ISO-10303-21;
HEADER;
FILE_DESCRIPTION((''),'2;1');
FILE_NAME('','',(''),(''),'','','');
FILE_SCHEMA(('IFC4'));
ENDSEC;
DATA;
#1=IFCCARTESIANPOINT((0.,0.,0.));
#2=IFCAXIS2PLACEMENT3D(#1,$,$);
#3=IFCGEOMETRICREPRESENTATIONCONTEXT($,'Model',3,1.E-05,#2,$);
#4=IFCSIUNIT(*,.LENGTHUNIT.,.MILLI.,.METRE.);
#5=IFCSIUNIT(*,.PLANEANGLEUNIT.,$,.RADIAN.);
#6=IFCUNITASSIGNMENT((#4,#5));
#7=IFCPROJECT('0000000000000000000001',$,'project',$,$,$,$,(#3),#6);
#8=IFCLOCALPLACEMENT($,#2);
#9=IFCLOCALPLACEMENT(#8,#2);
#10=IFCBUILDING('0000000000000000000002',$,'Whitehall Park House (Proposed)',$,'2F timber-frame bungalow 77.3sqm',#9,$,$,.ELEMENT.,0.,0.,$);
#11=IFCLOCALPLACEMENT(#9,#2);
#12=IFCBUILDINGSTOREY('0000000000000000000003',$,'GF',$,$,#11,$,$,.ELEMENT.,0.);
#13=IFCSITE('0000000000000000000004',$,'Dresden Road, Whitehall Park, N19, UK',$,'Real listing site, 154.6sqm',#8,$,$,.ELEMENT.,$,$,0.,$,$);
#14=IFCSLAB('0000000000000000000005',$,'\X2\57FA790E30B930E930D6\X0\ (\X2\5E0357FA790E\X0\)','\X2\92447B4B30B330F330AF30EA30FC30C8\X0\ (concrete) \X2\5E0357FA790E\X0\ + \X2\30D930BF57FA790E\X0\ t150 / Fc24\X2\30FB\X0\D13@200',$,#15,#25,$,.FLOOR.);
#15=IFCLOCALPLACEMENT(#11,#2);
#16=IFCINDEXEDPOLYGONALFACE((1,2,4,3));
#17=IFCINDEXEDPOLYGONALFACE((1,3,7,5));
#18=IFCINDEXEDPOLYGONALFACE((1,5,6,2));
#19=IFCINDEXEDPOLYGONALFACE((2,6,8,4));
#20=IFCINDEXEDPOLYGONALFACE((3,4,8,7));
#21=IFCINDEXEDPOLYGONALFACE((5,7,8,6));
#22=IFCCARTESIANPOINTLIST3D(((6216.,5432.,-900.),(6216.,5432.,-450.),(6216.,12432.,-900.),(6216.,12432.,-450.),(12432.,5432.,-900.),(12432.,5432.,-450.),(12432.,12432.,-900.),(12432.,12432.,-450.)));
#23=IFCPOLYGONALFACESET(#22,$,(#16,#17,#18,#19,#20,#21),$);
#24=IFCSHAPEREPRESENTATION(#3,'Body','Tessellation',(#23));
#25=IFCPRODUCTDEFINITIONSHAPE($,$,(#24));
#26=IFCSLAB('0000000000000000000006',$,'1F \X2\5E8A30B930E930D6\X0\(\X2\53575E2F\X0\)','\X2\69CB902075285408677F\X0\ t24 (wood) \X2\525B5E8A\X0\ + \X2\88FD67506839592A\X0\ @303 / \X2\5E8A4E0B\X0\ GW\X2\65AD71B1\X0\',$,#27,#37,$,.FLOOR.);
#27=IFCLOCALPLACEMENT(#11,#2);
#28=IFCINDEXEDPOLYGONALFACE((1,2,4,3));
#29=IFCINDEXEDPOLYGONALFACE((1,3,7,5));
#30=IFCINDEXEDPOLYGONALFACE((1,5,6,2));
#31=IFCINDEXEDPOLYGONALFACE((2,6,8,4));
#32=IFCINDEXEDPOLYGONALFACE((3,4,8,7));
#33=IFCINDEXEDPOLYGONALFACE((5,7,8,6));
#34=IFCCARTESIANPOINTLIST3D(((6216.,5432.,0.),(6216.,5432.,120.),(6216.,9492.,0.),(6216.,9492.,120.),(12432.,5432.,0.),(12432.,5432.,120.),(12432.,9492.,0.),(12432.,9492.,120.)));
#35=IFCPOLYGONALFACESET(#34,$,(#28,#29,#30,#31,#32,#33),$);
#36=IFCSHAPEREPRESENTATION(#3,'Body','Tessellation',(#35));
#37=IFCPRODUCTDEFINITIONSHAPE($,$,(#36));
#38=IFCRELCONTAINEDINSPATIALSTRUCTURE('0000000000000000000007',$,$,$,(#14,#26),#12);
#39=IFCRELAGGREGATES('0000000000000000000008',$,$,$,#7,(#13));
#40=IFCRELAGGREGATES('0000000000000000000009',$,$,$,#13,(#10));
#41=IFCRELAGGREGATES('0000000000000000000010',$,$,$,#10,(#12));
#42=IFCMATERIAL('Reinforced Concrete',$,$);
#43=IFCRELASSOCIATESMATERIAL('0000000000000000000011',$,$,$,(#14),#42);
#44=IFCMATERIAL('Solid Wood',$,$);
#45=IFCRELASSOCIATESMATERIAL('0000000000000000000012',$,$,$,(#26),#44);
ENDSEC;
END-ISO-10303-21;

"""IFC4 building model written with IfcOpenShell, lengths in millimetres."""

from ifc_helpers import new_model, si_unit, frame, frame_2d, origin, place, context, project, spatial, rectangle, extrude, material, element, save


model = new_model("IFC4")

# Units and contexts
model_context = context("Model", 3, precision=1e-05, world=origin())
ifc_project = project(units=[si_unit("LENGTHUNIT", "METRE", prefix="MILLI"), si_unit("PLANEANGLEUNIT", "RADIAN")], contexts=[model_context])

# Site, building, storey
site_placement = place(None, origin())
site = spatial("IfcSite", under=ifc_project, at=site_placement, Name="Dresden Road, Whitehall Park, N19, UK", ObjectType="Real listing site, 154.6sqm", CompositionType="ELEMENT", RefElevation=0.0)
building_placement = place(site_placement, origin())
building = spatial("IfcBuilding", under=site, at=building_placement, Name="Whitehall Park House (Proposed)", ObjectType="2F timber-frame bungalow 77.3sqm", CompositionType="ELEMENT", ElevationOfRefHeight=0.0, ElevationOfTerrain=0.0)
storey_placement = place(building_placement, origin())
storey = spatial("IfcBuildingStorey", under=building, at=storey_placement, Name="GF", CompositionType="ELEMENT", Elevation=0.0)

# Slabs
ifc_material_1 = material(Name="Reinforced Concrete")
slab_1_placement = place(storey_placement, frame((3108.0, 2716.0, -450.0)))
element("IfcSlab", 1, at=slab_1_placement, inside=storey, material=ifc_material_1, Name="基礎スラブ (布基礎)", Description="鉄筋コンクリート (concrete) 布基礎 + ベタ基礎 t150 / Fc24・D13@200", PredefinedType="FLOOR", context=model_context, shape_type="SweptSolid", body=[
    extrude(rectangle(XDim=6216.0, YDim=7000.0, at=frame_2d((3108.0, 3500.0))), frame((3108.0, 2716.0, -450.0)), (0.0, 0.0, 1.0), 450.0),
])
ifc_material_2 = material(Name="Solid Wood")
slab_2_placement = place(storey_placement, frame((3108.0, 2716.0, 0.0)))
element("IfcSlab", 2, at=slab_2_placement, inside=storey, material=ifc_material_2, Name="1F 床スラブ(南帯)", Description="構造用合板 t24 (wood) 剛床 + 製材根太 @303 / 床下 GW断熱", PredefinedType="FLOOR", context=model_context, shape_type="SweptSolid", body=[
    extrude(rectangle(XDim=6216.0, YDim=4060.0, at=frame_2d((3108.0, 2030.0))), frame((3108.0, 2716.0, 0.0)), (0.0, 0.0, 1.0), 120.0),
])

save(model, "model.ifc")
